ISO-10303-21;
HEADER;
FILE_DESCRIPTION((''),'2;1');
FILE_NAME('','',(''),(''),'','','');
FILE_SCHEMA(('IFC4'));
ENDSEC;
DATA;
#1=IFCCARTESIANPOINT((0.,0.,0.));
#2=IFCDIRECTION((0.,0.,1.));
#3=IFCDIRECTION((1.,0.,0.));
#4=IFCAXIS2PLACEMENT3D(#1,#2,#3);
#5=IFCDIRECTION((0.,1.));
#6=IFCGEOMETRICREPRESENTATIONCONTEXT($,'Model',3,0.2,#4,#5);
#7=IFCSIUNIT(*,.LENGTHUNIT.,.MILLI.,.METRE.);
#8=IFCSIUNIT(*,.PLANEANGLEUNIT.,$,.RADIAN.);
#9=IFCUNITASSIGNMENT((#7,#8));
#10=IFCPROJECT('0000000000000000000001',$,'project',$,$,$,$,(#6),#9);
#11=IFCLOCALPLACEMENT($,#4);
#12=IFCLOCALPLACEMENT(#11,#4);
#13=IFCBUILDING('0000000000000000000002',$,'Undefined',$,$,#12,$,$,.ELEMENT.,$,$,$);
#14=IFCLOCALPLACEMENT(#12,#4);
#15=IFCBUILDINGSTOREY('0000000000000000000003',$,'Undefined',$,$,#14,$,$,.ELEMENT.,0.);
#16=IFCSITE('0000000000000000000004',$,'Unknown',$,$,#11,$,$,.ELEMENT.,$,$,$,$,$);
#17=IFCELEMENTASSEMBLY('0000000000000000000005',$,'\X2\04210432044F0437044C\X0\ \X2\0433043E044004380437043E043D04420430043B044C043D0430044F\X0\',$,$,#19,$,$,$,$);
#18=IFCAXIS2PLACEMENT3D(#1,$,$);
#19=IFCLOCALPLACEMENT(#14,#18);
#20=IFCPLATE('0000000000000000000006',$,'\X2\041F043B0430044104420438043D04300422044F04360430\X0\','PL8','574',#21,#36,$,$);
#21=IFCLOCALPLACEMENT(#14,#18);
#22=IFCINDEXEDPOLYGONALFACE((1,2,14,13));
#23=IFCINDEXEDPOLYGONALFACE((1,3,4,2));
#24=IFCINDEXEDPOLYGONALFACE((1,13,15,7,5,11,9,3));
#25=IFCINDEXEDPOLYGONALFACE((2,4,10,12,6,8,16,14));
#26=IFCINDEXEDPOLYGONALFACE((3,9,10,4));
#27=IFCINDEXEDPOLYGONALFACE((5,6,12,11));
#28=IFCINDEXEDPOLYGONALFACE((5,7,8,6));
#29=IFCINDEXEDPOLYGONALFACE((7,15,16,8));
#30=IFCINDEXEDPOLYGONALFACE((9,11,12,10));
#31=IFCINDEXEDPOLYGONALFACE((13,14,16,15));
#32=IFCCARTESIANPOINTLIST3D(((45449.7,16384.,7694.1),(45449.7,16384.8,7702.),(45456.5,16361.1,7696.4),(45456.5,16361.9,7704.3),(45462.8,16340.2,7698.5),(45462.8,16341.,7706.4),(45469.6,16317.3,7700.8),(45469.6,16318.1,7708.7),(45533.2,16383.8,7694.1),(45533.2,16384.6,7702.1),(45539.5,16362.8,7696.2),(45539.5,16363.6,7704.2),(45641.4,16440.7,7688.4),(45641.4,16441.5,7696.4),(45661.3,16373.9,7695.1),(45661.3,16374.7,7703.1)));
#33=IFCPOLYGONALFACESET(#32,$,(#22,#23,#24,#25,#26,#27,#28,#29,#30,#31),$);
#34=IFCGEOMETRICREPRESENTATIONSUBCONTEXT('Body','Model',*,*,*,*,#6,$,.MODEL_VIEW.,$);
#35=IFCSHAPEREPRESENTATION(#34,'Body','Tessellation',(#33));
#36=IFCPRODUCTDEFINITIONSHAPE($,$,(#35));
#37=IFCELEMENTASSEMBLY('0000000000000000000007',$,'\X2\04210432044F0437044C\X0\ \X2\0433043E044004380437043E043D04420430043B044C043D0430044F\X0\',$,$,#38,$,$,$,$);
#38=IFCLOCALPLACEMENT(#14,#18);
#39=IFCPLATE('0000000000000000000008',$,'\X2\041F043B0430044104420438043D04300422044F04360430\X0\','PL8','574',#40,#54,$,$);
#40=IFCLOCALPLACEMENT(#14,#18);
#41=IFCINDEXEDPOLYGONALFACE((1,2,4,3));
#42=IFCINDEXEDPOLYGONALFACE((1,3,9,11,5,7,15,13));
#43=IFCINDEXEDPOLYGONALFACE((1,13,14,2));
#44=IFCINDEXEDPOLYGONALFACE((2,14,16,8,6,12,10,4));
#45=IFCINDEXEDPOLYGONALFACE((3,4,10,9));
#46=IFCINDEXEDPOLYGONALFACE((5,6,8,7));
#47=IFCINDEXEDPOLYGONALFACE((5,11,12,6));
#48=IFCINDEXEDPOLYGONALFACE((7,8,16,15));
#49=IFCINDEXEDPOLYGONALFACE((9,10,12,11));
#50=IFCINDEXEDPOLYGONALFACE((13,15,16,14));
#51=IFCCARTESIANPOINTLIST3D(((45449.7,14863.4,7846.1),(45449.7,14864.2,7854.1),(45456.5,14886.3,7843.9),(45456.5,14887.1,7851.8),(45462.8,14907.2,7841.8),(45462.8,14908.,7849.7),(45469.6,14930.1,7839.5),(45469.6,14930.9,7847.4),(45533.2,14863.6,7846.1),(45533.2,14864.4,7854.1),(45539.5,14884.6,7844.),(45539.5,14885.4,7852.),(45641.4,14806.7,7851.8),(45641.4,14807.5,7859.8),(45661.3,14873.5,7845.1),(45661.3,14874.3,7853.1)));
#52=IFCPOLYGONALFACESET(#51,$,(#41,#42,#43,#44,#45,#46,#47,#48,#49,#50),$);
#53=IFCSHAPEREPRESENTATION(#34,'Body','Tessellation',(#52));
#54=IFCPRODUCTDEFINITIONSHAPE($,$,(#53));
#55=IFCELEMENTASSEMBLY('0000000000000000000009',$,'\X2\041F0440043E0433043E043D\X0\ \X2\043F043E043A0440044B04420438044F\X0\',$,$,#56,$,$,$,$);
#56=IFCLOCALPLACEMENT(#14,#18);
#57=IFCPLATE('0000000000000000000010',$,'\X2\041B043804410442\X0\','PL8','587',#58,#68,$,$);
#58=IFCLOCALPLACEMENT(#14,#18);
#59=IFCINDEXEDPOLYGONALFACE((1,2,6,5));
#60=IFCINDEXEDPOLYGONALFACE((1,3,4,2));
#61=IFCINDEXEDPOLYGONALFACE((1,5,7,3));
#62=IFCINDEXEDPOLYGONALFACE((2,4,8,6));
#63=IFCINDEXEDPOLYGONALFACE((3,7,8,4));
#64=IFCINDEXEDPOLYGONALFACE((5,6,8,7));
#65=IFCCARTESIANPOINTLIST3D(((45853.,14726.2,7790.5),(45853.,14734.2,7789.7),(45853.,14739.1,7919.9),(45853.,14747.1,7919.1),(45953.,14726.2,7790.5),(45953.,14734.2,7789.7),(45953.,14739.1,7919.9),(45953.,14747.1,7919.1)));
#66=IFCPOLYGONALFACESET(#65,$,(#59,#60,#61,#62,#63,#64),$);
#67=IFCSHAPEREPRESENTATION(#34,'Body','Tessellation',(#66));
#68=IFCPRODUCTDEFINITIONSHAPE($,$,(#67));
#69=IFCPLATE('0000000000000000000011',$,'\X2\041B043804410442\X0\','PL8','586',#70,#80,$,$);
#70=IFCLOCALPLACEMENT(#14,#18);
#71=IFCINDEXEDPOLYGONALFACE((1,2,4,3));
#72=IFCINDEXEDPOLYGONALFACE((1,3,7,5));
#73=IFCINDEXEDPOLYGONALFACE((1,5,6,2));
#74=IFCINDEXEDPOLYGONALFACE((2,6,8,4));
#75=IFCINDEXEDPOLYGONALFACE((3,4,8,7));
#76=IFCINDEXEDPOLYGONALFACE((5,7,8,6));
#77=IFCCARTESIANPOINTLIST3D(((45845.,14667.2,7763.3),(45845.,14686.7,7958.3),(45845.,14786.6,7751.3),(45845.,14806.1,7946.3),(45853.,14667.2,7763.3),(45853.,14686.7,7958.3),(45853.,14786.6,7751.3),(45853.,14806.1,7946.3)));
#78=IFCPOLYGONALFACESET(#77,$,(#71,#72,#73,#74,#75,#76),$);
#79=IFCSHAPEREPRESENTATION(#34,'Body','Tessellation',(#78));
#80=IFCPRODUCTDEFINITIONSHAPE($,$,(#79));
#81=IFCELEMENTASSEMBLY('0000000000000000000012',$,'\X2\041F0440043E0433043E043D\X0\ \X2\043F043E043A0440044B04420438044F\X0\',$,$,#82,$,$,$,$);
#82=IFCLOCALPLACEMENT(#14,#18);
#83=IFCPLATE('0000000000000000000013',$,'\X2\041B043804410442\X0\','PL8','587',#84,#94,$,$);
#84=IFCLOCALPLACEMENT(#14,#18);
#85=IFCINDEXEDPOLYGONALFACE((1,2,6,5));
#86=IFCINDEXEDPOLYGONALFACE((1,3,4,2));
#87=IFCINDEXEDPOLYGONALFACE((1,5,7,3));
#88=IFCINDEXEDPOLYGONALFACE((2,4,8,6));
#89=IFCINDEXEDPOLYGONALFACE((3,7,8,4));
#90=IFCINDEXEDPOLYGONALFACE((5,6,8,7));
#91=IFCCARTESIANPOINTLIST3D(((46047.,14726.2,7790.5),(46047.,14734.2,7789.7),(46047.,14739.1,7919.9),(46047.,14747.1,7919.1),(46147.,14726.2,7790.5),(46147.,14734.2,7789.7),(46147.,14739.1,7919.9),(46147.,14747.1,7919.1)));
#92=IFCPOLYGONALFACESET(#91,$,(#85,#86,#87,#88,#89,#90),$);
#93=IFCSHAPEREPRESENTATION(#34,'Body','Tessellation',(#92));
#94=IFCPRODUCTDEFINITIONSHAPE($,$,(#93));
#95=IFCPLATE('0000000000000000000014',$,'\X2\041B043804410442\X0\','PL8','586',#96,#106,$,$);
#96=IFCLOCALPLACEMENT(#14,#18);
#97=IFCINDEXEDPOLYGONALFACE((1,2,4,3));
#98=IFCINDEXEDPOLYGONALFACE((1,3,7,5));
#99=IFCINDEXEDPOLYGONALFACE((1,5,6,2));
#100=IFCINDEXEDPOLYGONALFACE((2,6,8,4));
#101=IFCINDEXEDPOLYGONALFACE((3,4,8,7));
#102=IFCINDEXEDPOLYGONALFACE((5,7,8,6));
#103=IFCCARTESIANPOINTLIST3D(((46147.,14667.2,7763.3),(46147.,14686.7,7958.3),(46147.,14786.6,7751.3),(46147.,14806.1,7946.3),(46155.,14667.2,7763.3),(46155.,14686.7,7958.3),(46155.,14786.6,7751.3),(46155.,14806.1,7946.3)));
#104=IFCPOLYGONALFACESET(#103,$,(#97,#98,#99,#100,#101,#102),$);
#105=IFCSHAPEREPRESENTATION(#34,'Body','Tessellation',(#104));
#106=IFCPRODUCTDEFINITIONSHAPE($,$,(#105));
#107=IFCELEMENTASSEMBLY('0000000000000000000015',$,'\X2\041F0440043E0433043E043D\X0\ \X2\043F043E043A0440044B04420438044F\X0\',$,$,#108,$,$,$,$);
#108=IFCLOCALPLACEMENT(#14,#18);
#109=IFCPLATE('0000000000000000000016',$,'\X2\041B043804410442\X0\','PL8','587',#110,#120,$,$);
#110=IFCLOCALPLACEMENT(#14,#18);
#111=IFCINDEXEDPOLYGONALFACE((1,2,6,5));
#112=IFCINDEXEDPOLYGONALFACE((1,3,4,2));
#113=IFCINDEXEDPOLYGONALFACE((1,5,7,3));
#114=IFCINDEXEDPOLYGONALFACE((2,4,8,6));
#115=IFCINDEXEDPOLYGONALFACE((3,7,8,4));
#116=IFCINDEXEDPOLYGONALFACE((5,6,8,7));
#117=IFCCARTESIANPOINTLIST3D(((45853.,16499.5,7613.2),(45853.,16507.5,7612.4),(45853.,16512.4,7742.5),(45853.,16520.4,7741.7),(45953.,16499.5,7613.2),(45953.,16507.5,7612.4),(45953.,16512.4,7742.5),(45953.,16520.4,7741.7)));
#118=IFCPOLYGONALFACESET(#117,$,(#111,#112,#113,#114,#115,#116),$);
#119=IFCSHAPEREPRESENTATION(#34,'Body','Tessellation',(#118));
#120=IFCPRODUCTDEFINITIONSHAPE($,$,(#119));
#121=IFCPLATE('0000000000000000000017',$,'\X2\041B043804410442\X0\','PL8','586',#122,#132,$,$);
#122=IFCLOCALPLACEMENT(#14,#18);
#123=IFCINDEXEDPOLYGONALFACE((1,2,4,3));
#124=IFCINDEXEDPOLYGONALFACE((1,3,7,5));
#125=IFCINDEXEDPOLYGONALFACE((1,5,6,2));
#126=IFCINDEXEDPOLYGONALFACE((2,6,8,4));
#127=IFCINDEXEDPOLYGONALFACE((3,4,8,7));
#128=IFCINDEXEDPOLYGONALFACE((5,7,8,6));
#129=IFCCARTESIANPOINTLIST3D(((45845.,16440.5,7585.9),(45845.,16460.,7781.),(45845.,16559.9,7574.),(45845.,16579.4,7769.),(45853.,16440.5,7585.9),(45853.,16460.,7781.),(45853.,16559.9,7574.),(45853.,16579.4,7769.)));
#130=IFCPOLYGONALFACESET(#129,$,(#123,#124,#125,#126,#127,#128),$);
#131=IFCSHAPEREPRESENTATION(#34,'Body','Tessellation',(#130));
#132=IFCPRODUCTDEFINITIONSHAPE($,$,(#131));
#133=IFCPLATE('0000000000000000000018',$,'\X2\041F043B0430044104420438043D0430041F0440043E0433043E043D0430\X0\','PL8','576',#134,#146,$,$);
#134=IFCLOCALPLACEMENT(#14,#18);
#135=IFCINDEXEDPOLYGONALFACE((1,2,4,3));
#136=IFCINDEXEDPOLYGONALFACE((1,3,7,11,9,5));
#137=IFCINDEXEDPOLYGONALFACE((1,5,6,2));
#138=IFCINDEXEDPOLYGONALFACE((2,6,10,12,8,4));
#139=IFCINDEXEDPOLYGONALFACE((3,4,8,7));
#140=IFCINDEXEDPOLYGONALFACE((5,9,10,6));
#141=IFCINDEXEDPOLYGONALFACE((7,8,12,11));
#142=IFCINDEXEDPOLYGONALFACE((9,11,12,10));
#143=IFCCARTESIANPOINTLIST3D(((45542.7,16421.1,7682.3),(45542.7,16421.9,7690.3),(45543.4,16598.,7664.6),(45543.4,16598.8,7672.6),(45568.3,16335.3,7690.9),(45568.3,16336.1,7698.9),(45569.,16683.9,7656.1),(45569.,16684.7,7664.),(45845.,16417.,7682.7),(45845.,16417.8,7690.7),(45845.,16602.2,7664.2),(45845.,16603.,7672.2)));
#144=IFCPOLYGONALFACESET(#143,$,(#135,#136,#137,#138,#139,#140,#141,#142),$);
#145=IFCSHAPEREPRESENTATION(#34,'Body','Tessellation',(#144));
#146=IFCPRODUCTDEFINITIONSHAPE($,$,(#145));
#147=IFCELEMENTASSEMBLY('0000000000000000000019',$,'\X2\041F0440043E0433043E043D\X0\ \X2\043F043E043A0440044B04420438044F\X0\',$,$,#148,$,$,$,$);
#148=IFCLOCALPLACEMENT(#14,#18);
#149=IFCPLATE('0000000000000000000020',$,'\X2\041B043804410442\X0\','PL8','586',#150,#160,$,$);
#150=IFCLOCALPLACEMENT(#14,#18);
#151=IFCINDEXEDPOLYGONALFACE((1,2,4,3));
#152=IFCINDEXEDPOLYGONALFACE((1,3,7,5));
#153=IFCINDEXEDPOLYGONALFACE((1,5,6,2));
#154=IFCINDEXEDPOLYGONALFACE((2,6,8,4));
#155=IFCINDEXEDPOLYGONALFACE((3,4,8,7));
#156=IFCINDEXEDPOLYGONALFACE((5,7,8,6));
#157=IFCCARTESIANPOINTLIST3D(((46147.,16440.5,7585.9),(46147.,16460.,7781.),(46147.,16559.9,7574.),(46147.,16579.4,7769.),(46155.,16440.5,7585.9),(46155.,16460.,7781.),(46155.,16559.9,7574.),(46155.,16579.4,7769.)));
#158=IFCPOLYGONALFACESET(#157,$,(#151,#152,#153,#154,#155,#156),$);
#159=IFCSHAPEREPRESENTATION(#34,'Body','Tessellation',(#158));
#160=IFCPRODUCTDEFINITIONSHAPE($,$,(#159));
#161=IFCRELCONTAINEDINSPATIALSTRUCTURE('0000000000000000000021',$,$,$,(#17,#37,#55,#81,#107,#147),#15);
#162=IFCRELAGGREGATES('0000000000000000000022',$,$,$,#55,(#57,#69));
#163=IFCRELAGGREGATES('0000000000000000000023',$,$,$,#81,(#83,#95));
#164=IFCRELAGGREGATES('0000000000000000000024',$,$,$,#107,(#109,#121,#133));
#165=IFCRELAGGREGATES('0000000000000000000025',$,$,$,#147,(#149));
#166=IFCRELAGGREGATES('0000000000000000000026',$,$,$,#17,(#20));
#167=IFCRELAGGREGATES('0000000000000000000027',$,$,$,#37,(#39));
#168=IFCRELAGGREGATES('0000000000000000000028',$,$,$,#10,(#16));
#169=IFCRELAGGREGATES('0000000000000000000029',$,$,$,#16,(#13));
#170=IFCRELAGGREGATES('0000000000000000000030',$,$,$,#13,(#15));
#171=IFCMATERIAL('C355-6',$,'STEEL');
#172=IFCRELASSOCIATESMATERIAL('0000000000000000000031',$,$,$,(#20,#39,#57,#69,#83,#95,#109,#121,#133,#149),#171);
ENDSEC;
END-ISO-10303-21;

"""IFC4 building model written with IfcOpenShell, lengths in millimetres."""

from ifc_helpers import new_model, si_unit, direction, frame, origin_with_axes, place, context, subcontext, project, spatial, line, indexed_curve, outline, extrude, material, element, aggregate, save


model = new_model("IFC4")

# Units and contexts
model_context = context("Model", 3, precision=0.2, world=origin_with_axes(), true_north=direction((0.0, 1.0)))
body_context = subcontext(model_context, "Body", "Model", "MODEL_VIEW")
ifc_project = project(units=[si_unit("LENGTHUNIT", "METRE", prefix="MILLI"), si_unit("PLANEANGLEUNIT", "RADIAN")], contexts=[model_context])

# Site, building, storey
site_placement = place(None, origin_with_axes())
site = spatial("IfcSite", under=ifc_project, at=site_placement, Name="Unknown", CompositionType="ELEMENT")
building_placement = place(site_placement, origin_with_axes())
building = spatial("IfcBuilding", under=site, at=building_placement, Name="Undefined", CompositionType="ELEMENT")
storey_placement = place(building_placement, origin_with_axes())
storey = spatial("IfcBuildingStorey", under=building, at=storey_placement, Name="Undefined", CompositionType="ELEMENT", Elevation=0.0)

# Shared definitions
ifc_material_1 = material(Name="C355-6", Category="STEEL")

# Element assemblies, plates, voiding features
assembly_1_placement = place(storey_placement, frame((44657.9, 16114.1, 7725.1), z_axis=(0.28473, -0.95385, 0.095385), x_axis=(0.958608, 0.283317, -0.028332)))
assembly_1 = element("IfcElementAssembly", 1, at=assembly_1_placement, inside=storey, Name="Связь горизонтальная")
plate_1_placement = place(assembly_1_placement, frame((1036.3, 0.0, 35.0), z_axis=(0.0, 1.0, 0.0), x_axis=(0.0, 0.0, -1.0)))
plate_1 = element("IfcPlate", 2, at=plate_1_placement, material=ifc_material_1, Name="ПластинаТяжа", Description="PL8", ObjectType="574", context=body_context, shape_type="SolidModel", body=[
    extrude(outline(indexed_curve([(0.0, 0.0), (70.0, 0.0), (70.0, 200.0), (0.0, 200.0)], segments=[line(1, 2, 3, 4, 1)])), frame((0.0, 0.0, 4.0), z_axis=(0.0, 0.0, 1.0), x_axis=(1.0, 0.0, 0.0)), (0.0, 0.0, -1.0), 8.0),
])
voiding_feature_1_placement = place(plate_1_placement, frame((24.0, 120.0, 0.0), z_axis=(0.0, 0.0, 1.0), x_axis=(1.0, 0.0, 0.0)))
element("IfcVoidingFeature", 3, at=voiding_feature_1_placement, cuts=plate_1, Name="PLATE", ObjectType="(?)", PredefinedType="HOLE", context=body_context, shape_type="SolidModel", body=[
    extrude(outline(indexed_curve([(0.0, 0.0), (22.0, 0.0), (22.0, 85.0), (0.0, 85.0)], segments=[line(1, 2, 3, 4, 1)])), frame((0.0, 0.0, 6.5), z_axis=(0.0, 0.0, 1.0), x_axis=(1.0, 0.0, 0.0)), (0.0, 0.0, -1.0), 13.0),
])
assembly_2_placement = place(storey_placement, frame((44657.9, 15134.1, 7823.1), z_axis=(-0.28473, -0.95385, 0.095385), x_axis=(0.958608, -0.283317, 0.028332)))
assembly_2 = element("IfcElementAssembly", 4, at=assembly_2_placement, inside=storey, Name="Связь горизонтальная")
plate_2_placement = place(assembly_2_placement, frame((1036.3, 0.0, 35.0), z_axis=(0.0, 1.0, 0.0), x_axis=(0.0, 0.0, -1.0)))
plate_2 = element("IfcPlate", 5, at=plate_2_placement, material=ifc_material_1, Name="ПластинаТяжа", Description="PL8", ObjectType="574", context=body_context, shape_type="SolidModel", body=[
    extrude(outline(indexed_curve([(0.0, 0.0), (70.0, 0.0), (70.0, 200.0), (0.0, 200.0)], segments=[line(1, 2, 3, 4, 1)])), frame((0.0, 0.0, 4.0), z_axis=(0.0, 0.0, 1.0), x_axis=(1.0, 0.0, 0.0)), (0.0, 0.0, -1.0), 8.0),
])
voiding_feature_2_placement = place(plate_2_placement, frame((24.0, 120.0, 0.0), z_axis=(0.0, 0.0, 1.0), x_axis=(1.0, 0.0, 0.0)))
element("IfcVoidingFeature", 6, at=voiding_feature_2_placement, cuts=plate_2, Name="PLATE", ObjectType="(?)", PredefinedType="HOLE", context=body_context, shape_type="SolidModel", body=[
    extrude(outline(indexed_curve([(0.0, 0.0), (22.0, 0.0), (22.0, 85.0), (0.0, 85.0)], segments=[line(1, 2, 3, 4, 1)])), frame((0.0, 0.0, 6.5), z_axis=(0.0, 0.0, 1.0), x_axis=(1.0, 0.0, 0.0)), (0.0, 0.0, -1.0), 13.0),
])

# Element assemblies, plates
assembly_3_placement = place(storey_placement, frame((46000.0, 14736.7, 7854.8), z_axis=(0.0, -0.995037, 0.099504), x_axis=(-1.0, 0.0, 0.0)))
assembly_3 = element("IfcElementAssembly", 7, at=assembly_3_placement, inside=storey, Name="Прогон покрытия")
plate_3_placement = place(assembly_3_placement, frame((47.0, -65.0, 0.0), z_axis=(0.0, 0.0, 1.0), x_axis=(1.0, 0.0, 0.0)))
plate_3 = element("IfcPlate", 8, at=plate_3_placement, material=ifc_material_1, Name="Лист", Description="PL8", ObjectType="587", context=body_context, shape_type="SolidModel", body=[
    extrude(outline(indexed_curve([(0.0, 0.0), (100.0, 0.0), (100.0, 130.0), (0.0, 130.0)], segments=[line(1, 2, 3, 4, 1)])), frame((0.0, 0.0, 4.0), z_axis=(0.0, 0.0, 1.0), x_axis=(1.0, 0.0, 0.0)), (0.0, 0.0, -1.0), 8.0),
])
plate_4_placement = place(assembly_3_placement, frame((151.0, -98.0, -60.0), z_axis=(-1.0, 0.0, 0.0), x_axis=(0.0, 0.0, 1.0)))
plate_4 = element("IfcPlate", 9, at=plate_4_placement, material=ifc_material_1, Name="Лист", Description="PL8", ObjectType="586", context=body_context, shape_type="SolidModel", body=[
    extrude(outline(indexed_curve([(0.0, 0.0), (120.0, 0.0), (120.0, 196.0), (0.0, 196.0)], segments=[line(1, 2, 3, 4, 1)])), frame((0.0, 0.0, 4.0), z_axis=(0.0, 0.0, 1.0), x_axis=(1.0, 0.0, 0.0)), (0.0, 0.0, -1.0), 8.0),
])
aggregate(assembly_3, [plate_3, plate_4])
assembly_4_placement = place(storey_placement, frame((50000.0, 14736.7, 7854.8), z_axis=(0.0, -0.995037, 0.099504), x_axis=(-1.0, 0.0, 0.0)))
assembly_4 = element("IfcElementAssembly", 10, at=assembly_4_placement, inside=storey, Name="Прогон покрытия")
plate_5_placement = place(assembly_4_placement, frame((3953.0, 65.0, 0.0), z_axis=(0.0, 0.0, 1.0), x_axis=(-1.0, 0.0, 0.0)))
plate_5 = element("IfcPlate", 11, at=plate_5_placement, material=ifc_material_1, Name="Лист", Description="PL8", ObjectType="587", context=body_context, shape_type="SolidModel", body=[
    extrude(outline(indexed_curve([(0.0, 0.0), (100.0, 0.0), (100.0, 130.0), (0.0, 130.0)], segments=[line(1, 2, 3, 4, 1)])), frame((0.0, 0.0, 4.0), z_axis=(0.0, 0.0, 1.0), x_axis=(1.0, 0.0, 0.0)), (0.0, 0.0, -1.0), 8.0),
])
plate_6_placement = place(assembly_4_placement, frame((3849.0, -98.0, 60.0), z_axis=(1.0, 0.0, 0.0), x_axis=(0.0, 0.0, -1.0)))
plate_6 = element("IfcPlate", 12, at=plate_6_placement, material=ifc_material_1, Name="Лист", Description="PL8", ObjectType="586", context=body_context, shape_type="SolidModel", body=[
    extrude(outline(indexed_curve([(0.0, 0.0), (120.0, 0.0), (120.0, 196.0), (0.0, 196.0)], segments=[line(1, 2, 3, 4, 1)])), frame((0.0, 0.0, 4.0), z_axis=(0.0, 0.0, 1.0), x_axis=(1.0, 0.0, 0.0)), (0.0, 0.0, -1.0), 8.0),
])
aggregate(assembly_4, [plate_5, plate_6])
assembly_5_placement = place(storey_placement, frame((46000.0, 16510.0, 7677.5), z_axis=(0.0, -0.995037, 0.099504), x_axis=(-1.0, 0.0, 0.0)))
assembly_5 = element("IfcElementAssembly", 13, at=assembly_5_placement, inside=storey, Name="Прогон покрытия")
plate_7_placement = place(assembly_5_placement, frame((47.0, -65.0, 0.0), z_axis=(0.0, 0.0, 1.0), x_axis=(1.0, 0.0, 0.0)))
plate_7 = element("IfcPlate", 14, at=plate_7_placement, material=ifc_material_1, Name="Лист", Description="PL8", ObjectType="587", context=body_context, shape_type="SolidModel", body=[
    extrude(outline(indexed_curve([(0.0, 0.0), (100.0, 0.0), (100.0, 130.0), (0.0, 130.0)], segments=[line(1, 2, 3, 4, 1)])), frame((0.0, 0.0, 4.0), z_axis=(0.0, 0.0, 1.0), x_axis=(1.0, 0.0, 0.0)), (0.0, 0.0, -1.0), 8.0),
])
plate_8_placement = place(assembly_5_placement, frame((151.0, -98.0, -60.0), z_axis=(-1.0, 0.0, 0.0), x_axis=(0.0, 0.0, 1.0)))
plate_8 = element("IfcPlate", 15, at=plate_8_placement, material=ifc_material_1, Name="Лист", Description="PL8", ObjectType="586", context=body_context, shape_type="SolidModel", body=[
    extrude(outline(indexed_curve([(0.0, 0.0), (120.0, 0.0), (120.0, 196.0), (0.0, 196.0)], segments=[line(1, 2, 3, 4, 1)])), frame((0.0, 0.0, 4.0), z_axis=(0.0, 0.0, 1.0), x_axis=(1.0, 0.0, 0.0)), (0.0, 0.0, -1.0), 8.0),
])
plate_9_placement = place(assembly_5_placement, frame((155.0, 0.0, 93.0), z_axis=(0.0, -1.0, 0.0), x_axis=(0.0, 0.0, -1.0)))
plate_9 = element("IfcPlate", 16, at=plate_9_placement, material=ifc_material_1, Name="ПластинаПрогона", Description="PL8", ObjectType="576", context=body_context, shape_type="SolidModel", body=[
    extrude(outline(indexed_curve([(0.0, 0.0), (186.1, 0.0), (268.2, 276.0), (181.9, 301.6), (4.1, 302.3), (-82.2, 276.7)], segments=[line(1, 2, 3, 4, 5, 6, 1)])), frame((0.0, 0.0, 4.0), z_axis=(0.0, 0.0, 1.0), x_axis=(1.0, 0.0, 0.0)), (0.0, 0.0, -1.0), 8.0),
])
aggregate(assembly_5, [plate_7, plate_8, plate_9])
assembly_6_placement = place(storey_placement, frame((50000.0, 16510.0, 7677.5), z_axis=(0.0, -0.995037, 0.099504), x_axis=(-1.0, 0.0, 0.0)))
assembly_6 = element("IfcElementAssembly", 17, at=assembly_6_placement, inside=storey, Name="Прогон покрытия")
plate_10_placement = place(assembly_6_placement, frame((3849.0, -98.0, 60.0), z_axis=(1.0, 0.0, 0.0), x_axis=(0.0, 0.0, -1.0)))
plate_10 = element("IfcPlate", 18, at=plate_10_placement, material=ifc_material_1, Name="Лист", Description="PL8", ObjectType="586", context=body_context, shape_type="SolidModel", body=[
    extrude(outline(indexed_curve([(0.0, 0.0), (120.0, 0.0), (120.0, 196.0), (0.0, 196.0)], segments=[line(1, 2, 3, 4, 1)])), frame((0.0, 0.0, 4.0), z_axis=(0.0, 0.0, 1.0), x_axis=(1.0, 0.0, 0.0)), (0.0, 0.0, -1.0), 8.0),
])
aggregate(assembly_6, [plate_10])

aggregate(assembly_1, [plate_1])
aggregate(assembly_2, [plate_2])

save(model, "model.ifc")
